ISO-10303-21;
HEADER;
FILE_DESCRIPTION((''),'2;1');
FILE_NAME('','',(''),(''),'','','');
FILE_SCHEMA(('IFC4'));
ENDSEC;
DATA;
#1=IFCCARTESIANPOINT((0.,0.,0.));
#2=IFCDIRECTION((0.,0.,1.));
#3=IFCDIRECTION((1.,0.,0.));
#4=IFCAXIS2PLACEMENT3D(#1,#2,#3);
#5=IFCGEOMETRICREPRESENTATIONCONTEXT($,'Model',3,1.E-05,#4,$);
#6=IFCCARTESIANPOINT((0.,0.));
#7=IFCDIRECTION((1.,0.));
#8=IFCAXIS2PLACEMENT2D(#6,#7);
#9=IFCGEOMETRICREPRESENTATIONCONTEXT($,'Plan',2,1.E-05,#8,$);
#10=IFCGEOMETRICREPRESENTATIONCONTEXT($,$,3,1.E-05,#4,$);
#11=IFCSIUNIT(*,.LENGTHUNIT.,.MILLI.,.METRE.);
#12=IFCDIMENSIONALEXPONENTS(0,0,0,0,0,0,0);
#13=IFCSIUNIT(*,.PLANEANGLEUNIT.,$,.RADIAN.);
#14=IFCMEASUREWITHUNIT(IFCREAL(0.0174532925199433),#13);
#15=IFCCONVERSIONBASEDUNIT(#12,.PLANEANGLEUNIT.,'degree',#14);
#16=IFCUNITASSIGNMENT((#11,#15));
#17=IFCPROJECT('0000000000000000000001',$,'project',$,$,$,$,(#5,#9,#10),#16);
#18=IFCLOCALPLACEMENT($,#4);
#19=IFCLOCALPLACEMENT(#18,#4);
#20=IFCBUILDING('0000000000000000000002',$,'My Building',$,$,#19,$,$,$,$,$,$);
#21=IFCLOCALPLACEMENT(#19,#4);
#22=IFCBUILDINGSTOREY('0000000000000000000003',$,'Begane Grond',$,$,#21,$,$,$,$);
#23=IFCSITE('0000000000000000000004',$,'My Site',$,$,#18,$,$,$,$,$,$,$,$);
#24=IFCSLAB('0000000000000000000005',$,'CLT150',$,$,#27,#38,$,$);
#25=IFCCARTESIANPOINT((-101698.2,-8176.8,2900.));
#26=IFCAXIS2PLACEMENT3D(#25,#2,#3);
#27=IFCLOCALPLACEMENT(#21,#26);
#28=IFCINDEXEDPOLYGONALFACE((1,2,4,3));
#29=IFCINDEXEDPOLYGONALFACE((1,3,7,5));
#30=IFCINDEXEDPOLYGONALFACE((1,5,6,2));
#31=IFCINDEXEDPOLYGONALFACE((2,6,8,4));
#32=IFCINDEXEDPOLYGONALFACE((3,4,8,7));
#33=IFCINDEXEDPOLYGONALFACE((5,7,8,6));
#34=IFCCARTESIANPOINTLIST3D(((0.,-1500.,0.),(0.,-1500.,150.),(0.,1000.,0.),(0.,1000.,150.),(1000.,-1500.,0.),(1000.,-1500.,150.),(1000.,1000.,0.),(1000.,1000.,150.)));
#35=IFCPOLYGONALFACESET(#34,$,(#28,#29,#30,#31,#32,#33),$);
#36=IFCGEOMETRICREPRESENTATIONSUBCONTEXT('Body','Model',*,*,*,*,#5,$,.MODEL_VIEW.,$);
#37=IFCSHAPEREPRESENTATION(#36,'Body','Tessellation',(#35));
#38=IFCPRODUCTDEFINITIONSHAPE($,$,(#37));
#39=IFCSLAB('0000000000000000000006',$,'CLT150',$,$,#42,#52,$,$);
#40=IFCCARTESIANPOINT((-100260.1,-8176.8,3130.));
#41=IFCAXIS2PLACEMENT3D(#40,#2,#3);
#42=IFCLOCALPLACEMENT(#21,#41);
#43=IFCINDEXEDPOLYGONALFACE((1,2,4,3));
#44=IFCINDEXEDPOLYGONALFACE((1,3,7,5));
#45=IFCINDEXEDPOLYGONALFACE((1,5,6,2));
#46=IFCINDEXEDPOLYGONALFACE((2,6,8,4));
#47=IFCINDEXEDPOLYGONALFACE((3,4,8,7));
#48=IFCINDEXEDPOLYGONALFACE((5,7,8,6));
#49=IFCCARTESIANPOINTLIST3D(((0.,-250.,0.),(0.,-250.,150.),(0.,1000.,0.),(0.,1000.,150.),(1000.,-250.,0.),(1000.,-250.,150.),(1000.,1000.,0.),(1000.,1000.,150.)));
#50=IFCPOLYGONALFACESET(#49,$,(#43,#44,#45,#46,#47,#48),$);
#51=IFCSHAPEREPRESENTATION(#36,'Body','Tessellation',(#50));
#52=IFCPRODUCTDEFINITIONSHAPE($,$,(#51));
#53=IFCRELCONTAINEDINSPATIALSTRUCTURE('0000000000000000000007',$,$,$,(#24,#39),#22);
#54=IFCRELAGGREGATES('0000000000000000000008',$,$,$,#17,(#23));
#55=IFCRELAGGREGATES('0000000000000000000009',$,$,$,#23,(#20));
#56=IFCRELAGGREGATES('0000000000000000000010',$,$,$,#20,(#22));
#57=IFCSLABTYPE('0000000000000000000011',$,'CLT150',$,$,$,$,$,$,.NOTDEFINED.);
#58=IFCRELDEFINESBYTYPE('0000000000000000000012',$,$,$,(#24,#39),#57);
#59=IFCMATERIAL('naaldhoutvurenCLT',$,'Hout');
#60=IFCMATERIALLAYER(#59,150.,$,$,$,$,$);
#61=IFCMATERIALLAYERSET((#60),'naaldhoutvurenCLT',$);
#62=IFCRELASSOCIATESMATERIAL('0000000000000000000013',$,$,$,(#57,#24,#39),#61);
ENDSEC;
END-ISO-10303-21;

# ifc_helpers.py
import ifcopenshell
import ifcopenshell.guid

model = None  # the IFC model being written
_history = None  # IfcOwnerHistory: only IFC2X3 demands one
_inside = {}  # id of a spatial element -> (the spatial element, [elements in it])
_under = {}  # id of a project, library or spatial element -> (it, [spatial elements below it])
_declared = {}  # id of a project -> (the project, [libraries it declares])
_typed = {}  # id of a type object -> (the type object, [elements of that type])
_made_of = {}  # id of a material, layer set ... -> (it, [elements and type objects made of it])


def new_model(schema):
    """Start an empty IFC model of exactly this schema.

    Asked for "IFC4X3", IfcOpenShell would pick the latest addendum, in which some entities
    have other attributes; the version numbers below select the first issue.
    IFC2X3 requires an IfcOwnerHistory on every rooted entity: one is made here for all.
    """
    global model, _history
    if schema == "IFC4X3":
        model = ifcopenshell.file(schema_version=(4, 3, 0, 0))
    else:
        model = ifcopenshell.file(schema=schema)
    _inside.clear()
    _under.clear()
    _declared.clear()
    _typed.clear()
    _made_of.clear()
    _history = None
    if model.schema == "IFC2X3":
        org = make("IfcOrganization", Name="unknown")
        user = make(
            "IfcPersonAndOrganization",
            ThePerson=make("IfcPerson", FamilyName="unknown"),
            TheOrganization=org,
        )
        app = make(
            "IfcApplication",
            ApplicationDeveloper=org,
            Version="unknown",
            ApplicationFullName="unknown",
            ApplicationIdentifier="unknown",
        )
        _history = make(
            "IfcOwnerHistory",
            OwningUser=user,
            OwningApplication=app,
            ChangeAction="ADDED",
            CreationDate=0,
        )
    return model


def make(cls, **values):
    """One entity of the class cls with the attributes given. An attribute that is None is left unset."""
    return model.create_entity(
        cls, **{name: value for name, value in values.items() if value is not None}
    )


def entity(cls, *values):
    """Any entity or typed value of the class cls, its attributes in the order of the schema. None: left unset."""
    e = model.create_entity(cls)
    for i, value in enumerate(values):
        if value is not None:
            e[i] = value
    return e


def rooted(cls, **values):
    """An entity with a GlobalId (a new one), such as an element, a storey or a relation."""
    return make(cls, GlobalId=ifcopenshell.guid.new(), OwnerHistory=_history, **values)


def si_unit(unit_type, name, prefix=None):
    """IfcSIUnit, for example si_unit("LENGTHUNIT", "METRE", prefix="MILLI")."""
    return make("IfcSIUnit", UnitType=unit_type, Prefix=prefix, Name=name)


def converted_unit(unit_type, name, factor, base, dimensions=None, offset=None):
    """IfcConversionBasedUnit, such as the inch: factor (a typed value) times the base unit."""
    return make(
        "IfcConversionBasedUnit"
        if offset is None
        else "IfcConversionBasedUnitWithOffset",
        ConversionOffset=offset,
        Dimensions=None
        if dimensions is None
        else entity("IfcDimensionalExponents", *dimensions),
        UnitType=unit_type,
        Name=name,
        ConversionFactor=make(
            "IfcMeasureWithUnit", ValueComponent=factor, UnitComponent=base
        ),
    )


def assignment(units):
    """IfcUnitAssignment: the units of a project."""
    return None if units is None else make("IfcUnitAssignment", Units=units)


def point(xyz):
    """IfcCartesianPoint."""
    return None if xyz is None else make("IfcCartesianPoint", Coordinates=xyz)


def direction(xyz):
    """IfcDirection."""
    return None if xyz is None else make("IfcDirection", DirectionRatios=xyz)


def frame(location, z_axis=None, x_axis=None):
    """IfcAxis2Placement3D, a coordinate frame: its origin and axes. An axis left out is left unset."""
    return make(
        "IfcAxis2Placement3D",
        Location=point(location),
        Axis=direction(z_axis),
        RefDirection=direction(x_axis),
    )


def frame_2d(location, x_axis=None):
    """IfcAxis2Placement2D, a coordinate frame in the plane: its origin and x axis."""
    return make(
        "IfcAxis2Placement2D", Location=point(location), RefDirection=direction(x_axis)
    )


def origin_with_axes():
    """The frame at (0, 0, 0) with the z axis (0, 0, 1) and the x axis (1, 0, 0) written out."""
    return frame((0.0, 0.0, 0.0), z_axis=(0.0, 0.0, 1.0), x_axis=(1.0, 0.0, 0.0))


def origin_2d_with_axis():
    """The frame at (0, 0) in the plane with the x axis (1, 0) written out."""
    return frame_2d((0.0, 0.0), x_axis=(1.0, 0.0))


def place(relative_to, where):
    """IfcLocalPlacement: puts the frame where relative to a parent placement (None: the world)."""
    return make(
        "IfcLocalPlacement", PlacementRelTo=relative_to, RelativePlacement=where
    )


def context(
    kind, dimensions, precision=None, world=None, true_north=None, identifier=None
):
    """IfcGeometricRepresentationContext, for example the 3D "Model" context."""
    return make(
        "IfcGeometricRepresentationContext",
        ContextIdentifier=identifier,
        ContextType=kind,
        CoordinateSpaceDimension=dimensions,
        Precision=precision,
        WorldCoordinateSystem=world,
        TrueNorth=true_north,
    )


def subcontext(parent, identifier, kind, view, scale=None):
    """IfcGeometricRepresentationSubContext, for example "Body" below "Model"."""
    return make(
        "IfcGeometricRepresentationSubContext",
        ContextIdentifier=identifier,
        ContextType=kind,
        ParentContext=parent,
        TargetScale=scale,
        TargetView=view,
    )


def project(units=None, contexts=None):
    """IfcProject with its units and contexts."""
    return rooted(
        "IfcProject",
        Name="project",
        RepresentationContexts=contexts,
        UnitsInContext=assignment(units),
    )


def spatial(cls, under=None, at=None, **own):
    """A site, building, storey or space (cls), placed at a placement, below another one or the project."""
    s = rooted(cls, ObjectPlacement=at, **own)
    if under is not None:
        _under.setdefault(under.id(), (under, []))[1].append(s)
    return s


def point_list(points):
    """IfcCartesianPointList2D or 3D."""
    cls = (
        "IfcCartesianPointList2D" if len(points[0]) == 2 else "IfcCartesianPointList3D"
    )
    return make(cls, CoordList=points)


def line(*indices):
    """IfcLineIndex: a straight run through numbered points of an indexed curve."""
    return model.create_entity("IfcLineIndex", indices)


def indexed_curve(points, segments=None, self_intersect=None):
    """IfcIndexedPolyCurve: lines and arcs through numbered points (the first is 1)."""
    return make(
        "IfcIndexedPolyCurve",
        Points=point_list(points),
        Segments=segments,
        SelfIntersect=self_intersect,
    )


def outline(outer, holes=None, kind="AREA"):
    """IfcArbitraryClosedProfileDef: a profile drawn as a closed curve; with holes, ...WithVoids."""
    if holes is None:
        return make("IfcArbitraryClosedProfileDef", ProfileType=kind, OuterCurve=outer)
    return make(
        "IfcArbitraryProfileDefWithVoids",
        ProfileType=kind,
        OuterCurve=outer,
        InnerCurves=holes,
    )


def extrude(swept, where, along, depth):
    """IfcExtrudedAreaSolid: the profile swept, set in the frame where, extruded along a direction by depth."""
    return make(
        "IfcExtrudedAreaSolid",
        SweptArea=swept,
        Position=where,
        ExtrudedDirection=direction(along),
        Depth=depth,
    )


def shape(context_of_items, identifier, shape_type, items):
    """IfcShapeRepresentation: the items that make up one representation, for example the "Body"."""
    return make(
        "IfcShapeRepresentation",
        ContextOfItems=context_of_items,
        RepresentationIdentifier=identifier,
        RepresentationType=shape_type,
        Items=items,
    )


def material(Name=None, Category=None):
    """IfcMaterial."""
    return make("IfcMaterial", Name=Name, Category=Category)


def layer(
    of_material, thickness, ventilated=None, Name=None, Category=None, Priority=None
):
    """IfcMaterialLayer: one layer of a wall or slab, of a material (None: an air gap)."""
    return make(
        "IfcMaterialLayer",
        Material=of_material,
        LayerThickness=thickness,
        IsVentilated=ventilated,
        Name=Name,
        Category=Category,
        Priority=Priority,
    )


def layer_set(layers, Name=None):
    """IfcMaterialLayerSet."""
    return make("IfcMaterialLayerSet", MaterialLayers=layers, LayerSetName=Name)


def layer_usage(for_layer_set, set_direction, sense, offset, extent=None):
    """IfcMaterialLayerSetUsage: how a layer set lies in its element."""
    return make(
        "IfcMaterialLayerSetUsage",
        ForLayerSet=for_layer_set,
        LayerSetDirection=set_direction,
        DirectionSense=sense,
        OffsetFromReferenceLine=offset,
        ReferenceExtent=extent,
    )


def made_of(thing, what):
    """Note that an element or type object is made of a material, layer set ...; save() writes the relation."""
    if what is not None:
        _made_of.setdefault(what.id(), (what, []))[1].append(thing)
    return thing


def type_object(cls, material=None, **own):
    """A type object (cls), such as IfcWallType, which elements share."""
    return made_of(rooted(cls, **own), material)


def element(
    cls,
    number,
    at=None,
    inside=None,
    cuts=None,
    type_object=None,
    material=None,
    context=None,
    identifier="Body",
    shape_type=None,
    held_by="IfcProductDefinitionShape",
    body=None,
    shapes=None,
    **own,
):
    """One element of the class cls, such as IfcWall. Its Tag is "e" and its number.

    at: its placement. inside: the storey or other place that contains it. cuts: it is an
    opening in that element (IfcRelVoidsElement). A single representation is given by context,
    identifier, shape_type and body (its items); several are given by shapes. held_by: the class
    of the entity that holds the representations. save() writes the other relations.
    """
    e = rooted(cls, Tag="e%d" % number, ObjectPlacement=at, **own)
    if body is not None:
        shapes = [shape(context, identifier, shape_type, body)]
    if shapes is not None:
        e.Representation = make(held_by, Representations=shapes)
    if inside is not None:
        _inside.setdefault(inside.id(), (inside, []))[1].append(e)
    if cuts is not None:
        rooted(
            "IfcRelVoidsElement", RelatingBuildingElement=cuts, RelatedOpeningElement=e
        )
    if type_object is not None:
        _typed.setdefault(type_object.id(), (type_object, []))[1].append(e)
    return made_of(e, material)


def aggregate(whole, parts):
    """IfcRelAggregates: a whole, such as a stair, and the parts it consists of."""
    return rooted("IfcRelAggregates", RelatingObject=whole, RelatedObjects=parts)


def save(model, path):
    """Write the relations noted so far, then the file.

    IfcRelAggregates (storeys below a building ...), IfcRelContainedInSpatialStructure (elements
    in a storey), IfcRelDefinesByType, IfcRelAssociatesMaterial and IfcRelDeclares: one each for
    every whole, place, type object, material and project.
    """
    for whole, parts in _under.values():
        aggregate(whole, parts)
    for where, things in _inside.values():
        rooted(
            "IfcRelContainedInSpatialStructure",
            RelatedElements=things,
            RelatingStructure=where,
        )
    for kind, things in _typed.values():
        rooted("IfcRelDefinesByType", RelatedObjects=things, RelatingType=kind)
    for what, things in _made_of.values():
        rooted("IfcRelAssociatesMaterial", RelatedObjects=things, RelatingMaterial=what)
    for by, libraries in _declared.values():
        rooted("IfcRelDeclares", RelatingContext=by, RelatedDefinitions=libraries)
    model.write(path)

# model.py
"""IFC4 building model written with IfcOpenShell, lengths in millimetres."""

from ifc_helpers import new_model, entity, si_unit, converted_unit, frame, origin_with_axes, origin_2d_with_axis, place, context, subcontext, project, spatial, line, indexed_curve, outline, extrude, material, layer, layer_set, layer_usage, type_object, element, save


model = new_model("IFC4")

# Units and contexts
model_context = context("Model", 3, precision=1e-05, world=origin_with_axes())
plan_context = context("Plan", 2, precision=1e-05, world=origin_2d_with_axis())
context_of_model = context(None, 3, precision=1e-05, world=origin_with_axes())
body_context = subcontext(model_context, "Body", "Model", "MODEL_VIEW")
ifc_project = project(units=[si_unit("LENGTHUNIT", "METRE", prefix="MILLI"), converted_unit("PLANEANGLEUNIT", "degree", entity("IfcReal", 0.0174532925199433), si_unit("PLANEANGLEUNIT", "RADIAN"), dimensions=[0, 0, 0, 0, 0, 0, 0])], contexts=[model_context, plan_context, context_of_model])

# Site, building, storey
site_placement = place(None, frame((0.0, 0.0, 0.0), z_axis=(0.0, 0.0, 1.0), x_axis=(1.0, 0.0, 0.0)))
site = spatial("IfcSite", under=ifc_project, at=site_placement, Name="My Site")
building_placement = place(site_placement, origin_with_axes())
building = spatial("IfcBuilding", under=site, at=building_placement, Name="My Building")
storey_placement = place(building_placement, origin_with_axes())
storey = spatial("IfcBuildingStorey", under=building, at=storey_placement, Name="Begane Grond")

# Slabs
ifc_material_1 = material(Name="naaldhoutvurenCLT", Category="Hout")
ifc_layer_1 = layer(ifc_material_1, 150.0)
ifc_layer_set_1 = layer_set([ifc_layer_1], Name="naaldhoutvurenCLT")
ifc_layer_usage_1 = layer_usage(ifc_layer_set_1, "AXIS3", "POSITIVE", 0.0)
slab_type_1 = type_object("IfcSlabType", Name="CLT150", PredefinedType="NOTDEFINED", material=ifc_layer_set_1)
slab_1_placement = place(storey_placement, frame((-101698.2, -8176.8, 2900.0), z_axis=(0.0, 0.0, 1.0), x_axis=(1.0, 0.0, 0.0)))
element("IfcSlab", 1, at=slab_1_placement, inside=storey, type_object=slab_type_1, material=ifc_layer_usage_1, Name="CLT150", context=body_context, shape_type="SweptSolid", body=[
    extrude(outline(indexed_curve([(0.0, -1500.0), (1000.0, -1500.0), (1000.0, 1000.0), (0.0, 1000.0)], segments=[line(3, 2), line(2, 1), line(1, 4), line(4, 3)], self_intersect=False)), None, (0.0, 0.0, 1.0), 150.0),
])
ifc_layer_usage_2 = layer_usage(ifc_layer_set_1, "AXIS3", "POSITIVE", 0.0)
slab_2_placement = place(storey_placement, frame((-100260.1, -8176.8, 3130.0), z_axis=(0.0, 0.0, 1.0), x_axis=(1.0, 0.0, 0.0)))
element("IfcSlab", 2, at=slab_2_placement, inside=storey, type_object=slab_type_1, material=ifc_layer_usage_2, Name="CLT150", context=body_context, shape_type="SweptSolid", body=[
    extrude(outline(indexed_curve([(1000.0, 1000.0), (1000.0, -250.0), (0.0, -250.0), (0.0, 1000.0)], segments=[line(4, 1), line(1, 2), line(2, 3), line(3, 4)], self_intersect=False)), None, (0.0, 0.0, 1.0), 150.0),
])

save(model, "model.ifc")
